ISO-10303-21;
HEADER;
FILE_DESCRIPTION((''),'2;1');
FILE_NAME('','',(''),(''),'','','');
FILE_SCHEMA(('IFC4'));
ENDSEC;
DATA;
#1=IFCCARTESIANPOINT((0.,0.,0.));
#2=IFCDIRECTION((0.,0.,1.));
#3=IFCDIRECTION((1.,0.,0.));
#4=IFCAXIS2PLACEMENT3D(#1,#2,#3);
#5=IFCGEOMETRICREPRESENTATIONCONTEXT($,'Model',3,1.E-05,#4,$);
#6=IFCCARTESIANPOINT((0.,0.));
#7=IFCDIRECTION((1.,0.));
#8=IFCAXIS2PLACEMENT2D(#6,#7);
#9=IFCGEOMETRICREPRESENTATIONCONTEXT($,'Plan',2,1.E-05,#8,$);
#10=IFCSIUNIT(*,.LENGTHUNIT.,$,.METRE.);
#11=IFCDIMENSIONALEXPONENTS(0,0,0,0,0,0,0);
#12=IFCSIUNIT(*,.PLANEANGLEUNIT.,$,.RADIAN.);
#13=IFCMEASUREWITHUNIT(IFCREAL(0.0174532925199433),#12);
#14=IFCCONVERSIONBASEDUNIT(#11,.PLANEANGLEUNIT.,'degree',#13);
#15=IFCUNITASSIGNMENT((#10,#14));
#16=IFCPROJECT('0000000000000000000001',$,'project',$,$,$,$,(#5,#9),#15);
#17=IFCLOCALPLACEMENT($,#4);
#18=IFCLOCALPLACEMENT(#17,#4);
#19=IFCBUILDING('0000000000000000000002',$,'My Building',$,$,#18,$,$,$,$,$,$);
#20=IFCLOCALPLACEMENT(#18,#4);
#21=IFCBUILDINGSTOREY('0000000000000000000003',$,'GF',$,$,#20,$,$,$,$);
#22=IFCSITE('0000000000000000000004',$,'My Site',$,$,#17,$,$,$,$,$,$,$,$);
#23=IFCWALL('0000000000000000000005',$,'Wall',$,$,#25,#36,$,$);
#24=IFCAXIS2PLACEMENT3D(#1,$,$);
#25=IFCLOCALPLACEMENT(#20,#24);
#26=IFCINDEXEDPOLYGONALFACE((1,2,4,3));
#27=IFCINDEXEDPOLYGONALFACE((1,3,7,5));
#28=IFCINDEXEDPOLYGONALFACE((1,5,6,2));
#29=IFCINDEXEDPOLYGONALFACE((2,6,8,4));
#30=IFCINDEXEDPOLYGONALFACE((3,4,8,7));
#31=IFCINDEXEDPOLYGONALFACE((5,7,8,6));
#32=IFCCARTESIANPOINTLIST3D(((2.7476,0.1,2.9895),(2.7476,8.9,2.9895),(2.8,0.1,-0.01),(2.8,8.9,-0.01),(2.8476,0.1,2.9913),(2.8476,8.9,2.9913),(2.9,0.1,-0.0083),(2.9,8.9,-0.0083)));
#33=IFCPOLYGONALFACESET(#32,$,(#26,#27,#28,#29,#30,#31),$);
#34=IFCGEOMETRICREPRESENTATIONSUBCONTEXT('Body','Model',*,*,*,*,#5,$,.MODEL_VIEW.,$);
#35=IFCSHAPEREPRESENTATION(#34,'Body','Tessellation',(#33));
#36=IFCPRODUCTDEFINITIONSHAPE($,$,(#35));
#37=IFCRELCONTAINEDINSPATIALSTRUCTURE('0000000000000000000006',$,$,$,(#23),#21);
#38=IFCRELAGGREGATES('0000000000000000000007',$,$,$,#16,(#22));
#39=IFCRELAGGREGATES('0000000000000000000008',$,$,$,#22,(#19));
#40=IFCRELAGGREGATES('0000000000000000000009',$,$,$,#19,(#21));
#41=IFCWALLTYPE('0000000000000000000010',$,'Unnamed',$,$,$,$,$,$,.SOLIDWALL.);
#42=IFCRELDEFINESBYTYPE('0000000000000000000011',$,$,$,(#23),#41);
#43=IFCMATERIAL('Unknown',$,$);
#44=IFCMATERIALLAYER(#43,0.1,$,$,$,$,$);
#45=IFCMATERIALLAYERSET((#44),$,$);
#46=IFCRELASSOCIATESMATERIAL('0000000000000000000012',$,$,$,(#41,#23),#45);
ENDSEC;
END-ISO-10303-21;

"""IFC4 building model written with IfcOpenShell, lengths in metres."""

from ifc_helpers import new_model, entity, si_unit, converted_unit, frame, origin_with_axes, origin_2d_with_axis, place, context, subcontext, project, spatial, line, indexed_curve, outline, extrude, material, layer, layer_set, layer_usage, type_object, element, save


model = new_model("IFC4")

# Units and contexts
model_context = context("Model", 3, precision=1e-05, world=origin_with_axes())
plan_context = context("Plan", 2, precision=1e-05, world=origin_2d_with_axis())
body_context_1 = subcontext(model_context, "Body", "Model", "MODEL_VIEW")
ifc_project = project(units=[si_unit("LENGTHUNIT", "METRE"), converted_unit("PLANEANGLEUNIT", "degree", entity("IfcReal", 0.0174532925199433), si_unit("PLANEANGLEUNIT", "RADIAN"), dimensions=[0, 0, 0, 0, 0, 0, 0])], contexts=[model_context, plan_context])

# Site, building, storey
site_placement = place(None, origin_with_axes())
site = spatial("IfcSite", under=ifc_project, at=site_placement, Name="My Site")
building_placement = place(site_placement, origin_with_axes())
building = spatial("IfcBuilding", under=site, at=building_placement, Name="My Building")
storey_placement = place(building_placement, origin_with_axes())
storey = spatial("IfcBuildingStorey", under=building, at=storey_placement, Name="GF")

# Shared definitions
ifc_material = material(Name="Unknown")

# Shared definitions
ifc_layer_1 = layer(ifc_material, 0.1)
ifc_layer_set_1 = layer_set([ifc_layer_1])
wall_type = type_object("IfcWallType", Name="Unnamed", PredefinedType="SOLIDWALL", material=ifc_layer_set_1)

# Wall
ifc_layer_usage_1 = layer_usage(ifc_layer_set_1, "AXIS2", "POSITIVE", 0.0)
wall_1_placement = place(storey_placement, frame((2.8, 9.0, -0.01), z_axis=(-0.017452, 0.0, 0.999848), x_axis=(0.0, -1.0, 0.0)))
element("IfcWall", 1, at=wall_1_placement, inside=storey, type_object=wall_type, material=ifc_layer_usage_1, Name="Wall", context=body_context_1, shape_type="SweptSolid", body=[
    extrude(outline(indexed_curve([(0.1, 0.0), (0.1, 0.1), (8.9, 0.1), (8.9, 0.0)], segments=[line(1, 2, 3, 4, 1)])), origin_with_axes(), (0.0, 0.0, 1.0), 3.0),
])

save(model, "model.ifc")
